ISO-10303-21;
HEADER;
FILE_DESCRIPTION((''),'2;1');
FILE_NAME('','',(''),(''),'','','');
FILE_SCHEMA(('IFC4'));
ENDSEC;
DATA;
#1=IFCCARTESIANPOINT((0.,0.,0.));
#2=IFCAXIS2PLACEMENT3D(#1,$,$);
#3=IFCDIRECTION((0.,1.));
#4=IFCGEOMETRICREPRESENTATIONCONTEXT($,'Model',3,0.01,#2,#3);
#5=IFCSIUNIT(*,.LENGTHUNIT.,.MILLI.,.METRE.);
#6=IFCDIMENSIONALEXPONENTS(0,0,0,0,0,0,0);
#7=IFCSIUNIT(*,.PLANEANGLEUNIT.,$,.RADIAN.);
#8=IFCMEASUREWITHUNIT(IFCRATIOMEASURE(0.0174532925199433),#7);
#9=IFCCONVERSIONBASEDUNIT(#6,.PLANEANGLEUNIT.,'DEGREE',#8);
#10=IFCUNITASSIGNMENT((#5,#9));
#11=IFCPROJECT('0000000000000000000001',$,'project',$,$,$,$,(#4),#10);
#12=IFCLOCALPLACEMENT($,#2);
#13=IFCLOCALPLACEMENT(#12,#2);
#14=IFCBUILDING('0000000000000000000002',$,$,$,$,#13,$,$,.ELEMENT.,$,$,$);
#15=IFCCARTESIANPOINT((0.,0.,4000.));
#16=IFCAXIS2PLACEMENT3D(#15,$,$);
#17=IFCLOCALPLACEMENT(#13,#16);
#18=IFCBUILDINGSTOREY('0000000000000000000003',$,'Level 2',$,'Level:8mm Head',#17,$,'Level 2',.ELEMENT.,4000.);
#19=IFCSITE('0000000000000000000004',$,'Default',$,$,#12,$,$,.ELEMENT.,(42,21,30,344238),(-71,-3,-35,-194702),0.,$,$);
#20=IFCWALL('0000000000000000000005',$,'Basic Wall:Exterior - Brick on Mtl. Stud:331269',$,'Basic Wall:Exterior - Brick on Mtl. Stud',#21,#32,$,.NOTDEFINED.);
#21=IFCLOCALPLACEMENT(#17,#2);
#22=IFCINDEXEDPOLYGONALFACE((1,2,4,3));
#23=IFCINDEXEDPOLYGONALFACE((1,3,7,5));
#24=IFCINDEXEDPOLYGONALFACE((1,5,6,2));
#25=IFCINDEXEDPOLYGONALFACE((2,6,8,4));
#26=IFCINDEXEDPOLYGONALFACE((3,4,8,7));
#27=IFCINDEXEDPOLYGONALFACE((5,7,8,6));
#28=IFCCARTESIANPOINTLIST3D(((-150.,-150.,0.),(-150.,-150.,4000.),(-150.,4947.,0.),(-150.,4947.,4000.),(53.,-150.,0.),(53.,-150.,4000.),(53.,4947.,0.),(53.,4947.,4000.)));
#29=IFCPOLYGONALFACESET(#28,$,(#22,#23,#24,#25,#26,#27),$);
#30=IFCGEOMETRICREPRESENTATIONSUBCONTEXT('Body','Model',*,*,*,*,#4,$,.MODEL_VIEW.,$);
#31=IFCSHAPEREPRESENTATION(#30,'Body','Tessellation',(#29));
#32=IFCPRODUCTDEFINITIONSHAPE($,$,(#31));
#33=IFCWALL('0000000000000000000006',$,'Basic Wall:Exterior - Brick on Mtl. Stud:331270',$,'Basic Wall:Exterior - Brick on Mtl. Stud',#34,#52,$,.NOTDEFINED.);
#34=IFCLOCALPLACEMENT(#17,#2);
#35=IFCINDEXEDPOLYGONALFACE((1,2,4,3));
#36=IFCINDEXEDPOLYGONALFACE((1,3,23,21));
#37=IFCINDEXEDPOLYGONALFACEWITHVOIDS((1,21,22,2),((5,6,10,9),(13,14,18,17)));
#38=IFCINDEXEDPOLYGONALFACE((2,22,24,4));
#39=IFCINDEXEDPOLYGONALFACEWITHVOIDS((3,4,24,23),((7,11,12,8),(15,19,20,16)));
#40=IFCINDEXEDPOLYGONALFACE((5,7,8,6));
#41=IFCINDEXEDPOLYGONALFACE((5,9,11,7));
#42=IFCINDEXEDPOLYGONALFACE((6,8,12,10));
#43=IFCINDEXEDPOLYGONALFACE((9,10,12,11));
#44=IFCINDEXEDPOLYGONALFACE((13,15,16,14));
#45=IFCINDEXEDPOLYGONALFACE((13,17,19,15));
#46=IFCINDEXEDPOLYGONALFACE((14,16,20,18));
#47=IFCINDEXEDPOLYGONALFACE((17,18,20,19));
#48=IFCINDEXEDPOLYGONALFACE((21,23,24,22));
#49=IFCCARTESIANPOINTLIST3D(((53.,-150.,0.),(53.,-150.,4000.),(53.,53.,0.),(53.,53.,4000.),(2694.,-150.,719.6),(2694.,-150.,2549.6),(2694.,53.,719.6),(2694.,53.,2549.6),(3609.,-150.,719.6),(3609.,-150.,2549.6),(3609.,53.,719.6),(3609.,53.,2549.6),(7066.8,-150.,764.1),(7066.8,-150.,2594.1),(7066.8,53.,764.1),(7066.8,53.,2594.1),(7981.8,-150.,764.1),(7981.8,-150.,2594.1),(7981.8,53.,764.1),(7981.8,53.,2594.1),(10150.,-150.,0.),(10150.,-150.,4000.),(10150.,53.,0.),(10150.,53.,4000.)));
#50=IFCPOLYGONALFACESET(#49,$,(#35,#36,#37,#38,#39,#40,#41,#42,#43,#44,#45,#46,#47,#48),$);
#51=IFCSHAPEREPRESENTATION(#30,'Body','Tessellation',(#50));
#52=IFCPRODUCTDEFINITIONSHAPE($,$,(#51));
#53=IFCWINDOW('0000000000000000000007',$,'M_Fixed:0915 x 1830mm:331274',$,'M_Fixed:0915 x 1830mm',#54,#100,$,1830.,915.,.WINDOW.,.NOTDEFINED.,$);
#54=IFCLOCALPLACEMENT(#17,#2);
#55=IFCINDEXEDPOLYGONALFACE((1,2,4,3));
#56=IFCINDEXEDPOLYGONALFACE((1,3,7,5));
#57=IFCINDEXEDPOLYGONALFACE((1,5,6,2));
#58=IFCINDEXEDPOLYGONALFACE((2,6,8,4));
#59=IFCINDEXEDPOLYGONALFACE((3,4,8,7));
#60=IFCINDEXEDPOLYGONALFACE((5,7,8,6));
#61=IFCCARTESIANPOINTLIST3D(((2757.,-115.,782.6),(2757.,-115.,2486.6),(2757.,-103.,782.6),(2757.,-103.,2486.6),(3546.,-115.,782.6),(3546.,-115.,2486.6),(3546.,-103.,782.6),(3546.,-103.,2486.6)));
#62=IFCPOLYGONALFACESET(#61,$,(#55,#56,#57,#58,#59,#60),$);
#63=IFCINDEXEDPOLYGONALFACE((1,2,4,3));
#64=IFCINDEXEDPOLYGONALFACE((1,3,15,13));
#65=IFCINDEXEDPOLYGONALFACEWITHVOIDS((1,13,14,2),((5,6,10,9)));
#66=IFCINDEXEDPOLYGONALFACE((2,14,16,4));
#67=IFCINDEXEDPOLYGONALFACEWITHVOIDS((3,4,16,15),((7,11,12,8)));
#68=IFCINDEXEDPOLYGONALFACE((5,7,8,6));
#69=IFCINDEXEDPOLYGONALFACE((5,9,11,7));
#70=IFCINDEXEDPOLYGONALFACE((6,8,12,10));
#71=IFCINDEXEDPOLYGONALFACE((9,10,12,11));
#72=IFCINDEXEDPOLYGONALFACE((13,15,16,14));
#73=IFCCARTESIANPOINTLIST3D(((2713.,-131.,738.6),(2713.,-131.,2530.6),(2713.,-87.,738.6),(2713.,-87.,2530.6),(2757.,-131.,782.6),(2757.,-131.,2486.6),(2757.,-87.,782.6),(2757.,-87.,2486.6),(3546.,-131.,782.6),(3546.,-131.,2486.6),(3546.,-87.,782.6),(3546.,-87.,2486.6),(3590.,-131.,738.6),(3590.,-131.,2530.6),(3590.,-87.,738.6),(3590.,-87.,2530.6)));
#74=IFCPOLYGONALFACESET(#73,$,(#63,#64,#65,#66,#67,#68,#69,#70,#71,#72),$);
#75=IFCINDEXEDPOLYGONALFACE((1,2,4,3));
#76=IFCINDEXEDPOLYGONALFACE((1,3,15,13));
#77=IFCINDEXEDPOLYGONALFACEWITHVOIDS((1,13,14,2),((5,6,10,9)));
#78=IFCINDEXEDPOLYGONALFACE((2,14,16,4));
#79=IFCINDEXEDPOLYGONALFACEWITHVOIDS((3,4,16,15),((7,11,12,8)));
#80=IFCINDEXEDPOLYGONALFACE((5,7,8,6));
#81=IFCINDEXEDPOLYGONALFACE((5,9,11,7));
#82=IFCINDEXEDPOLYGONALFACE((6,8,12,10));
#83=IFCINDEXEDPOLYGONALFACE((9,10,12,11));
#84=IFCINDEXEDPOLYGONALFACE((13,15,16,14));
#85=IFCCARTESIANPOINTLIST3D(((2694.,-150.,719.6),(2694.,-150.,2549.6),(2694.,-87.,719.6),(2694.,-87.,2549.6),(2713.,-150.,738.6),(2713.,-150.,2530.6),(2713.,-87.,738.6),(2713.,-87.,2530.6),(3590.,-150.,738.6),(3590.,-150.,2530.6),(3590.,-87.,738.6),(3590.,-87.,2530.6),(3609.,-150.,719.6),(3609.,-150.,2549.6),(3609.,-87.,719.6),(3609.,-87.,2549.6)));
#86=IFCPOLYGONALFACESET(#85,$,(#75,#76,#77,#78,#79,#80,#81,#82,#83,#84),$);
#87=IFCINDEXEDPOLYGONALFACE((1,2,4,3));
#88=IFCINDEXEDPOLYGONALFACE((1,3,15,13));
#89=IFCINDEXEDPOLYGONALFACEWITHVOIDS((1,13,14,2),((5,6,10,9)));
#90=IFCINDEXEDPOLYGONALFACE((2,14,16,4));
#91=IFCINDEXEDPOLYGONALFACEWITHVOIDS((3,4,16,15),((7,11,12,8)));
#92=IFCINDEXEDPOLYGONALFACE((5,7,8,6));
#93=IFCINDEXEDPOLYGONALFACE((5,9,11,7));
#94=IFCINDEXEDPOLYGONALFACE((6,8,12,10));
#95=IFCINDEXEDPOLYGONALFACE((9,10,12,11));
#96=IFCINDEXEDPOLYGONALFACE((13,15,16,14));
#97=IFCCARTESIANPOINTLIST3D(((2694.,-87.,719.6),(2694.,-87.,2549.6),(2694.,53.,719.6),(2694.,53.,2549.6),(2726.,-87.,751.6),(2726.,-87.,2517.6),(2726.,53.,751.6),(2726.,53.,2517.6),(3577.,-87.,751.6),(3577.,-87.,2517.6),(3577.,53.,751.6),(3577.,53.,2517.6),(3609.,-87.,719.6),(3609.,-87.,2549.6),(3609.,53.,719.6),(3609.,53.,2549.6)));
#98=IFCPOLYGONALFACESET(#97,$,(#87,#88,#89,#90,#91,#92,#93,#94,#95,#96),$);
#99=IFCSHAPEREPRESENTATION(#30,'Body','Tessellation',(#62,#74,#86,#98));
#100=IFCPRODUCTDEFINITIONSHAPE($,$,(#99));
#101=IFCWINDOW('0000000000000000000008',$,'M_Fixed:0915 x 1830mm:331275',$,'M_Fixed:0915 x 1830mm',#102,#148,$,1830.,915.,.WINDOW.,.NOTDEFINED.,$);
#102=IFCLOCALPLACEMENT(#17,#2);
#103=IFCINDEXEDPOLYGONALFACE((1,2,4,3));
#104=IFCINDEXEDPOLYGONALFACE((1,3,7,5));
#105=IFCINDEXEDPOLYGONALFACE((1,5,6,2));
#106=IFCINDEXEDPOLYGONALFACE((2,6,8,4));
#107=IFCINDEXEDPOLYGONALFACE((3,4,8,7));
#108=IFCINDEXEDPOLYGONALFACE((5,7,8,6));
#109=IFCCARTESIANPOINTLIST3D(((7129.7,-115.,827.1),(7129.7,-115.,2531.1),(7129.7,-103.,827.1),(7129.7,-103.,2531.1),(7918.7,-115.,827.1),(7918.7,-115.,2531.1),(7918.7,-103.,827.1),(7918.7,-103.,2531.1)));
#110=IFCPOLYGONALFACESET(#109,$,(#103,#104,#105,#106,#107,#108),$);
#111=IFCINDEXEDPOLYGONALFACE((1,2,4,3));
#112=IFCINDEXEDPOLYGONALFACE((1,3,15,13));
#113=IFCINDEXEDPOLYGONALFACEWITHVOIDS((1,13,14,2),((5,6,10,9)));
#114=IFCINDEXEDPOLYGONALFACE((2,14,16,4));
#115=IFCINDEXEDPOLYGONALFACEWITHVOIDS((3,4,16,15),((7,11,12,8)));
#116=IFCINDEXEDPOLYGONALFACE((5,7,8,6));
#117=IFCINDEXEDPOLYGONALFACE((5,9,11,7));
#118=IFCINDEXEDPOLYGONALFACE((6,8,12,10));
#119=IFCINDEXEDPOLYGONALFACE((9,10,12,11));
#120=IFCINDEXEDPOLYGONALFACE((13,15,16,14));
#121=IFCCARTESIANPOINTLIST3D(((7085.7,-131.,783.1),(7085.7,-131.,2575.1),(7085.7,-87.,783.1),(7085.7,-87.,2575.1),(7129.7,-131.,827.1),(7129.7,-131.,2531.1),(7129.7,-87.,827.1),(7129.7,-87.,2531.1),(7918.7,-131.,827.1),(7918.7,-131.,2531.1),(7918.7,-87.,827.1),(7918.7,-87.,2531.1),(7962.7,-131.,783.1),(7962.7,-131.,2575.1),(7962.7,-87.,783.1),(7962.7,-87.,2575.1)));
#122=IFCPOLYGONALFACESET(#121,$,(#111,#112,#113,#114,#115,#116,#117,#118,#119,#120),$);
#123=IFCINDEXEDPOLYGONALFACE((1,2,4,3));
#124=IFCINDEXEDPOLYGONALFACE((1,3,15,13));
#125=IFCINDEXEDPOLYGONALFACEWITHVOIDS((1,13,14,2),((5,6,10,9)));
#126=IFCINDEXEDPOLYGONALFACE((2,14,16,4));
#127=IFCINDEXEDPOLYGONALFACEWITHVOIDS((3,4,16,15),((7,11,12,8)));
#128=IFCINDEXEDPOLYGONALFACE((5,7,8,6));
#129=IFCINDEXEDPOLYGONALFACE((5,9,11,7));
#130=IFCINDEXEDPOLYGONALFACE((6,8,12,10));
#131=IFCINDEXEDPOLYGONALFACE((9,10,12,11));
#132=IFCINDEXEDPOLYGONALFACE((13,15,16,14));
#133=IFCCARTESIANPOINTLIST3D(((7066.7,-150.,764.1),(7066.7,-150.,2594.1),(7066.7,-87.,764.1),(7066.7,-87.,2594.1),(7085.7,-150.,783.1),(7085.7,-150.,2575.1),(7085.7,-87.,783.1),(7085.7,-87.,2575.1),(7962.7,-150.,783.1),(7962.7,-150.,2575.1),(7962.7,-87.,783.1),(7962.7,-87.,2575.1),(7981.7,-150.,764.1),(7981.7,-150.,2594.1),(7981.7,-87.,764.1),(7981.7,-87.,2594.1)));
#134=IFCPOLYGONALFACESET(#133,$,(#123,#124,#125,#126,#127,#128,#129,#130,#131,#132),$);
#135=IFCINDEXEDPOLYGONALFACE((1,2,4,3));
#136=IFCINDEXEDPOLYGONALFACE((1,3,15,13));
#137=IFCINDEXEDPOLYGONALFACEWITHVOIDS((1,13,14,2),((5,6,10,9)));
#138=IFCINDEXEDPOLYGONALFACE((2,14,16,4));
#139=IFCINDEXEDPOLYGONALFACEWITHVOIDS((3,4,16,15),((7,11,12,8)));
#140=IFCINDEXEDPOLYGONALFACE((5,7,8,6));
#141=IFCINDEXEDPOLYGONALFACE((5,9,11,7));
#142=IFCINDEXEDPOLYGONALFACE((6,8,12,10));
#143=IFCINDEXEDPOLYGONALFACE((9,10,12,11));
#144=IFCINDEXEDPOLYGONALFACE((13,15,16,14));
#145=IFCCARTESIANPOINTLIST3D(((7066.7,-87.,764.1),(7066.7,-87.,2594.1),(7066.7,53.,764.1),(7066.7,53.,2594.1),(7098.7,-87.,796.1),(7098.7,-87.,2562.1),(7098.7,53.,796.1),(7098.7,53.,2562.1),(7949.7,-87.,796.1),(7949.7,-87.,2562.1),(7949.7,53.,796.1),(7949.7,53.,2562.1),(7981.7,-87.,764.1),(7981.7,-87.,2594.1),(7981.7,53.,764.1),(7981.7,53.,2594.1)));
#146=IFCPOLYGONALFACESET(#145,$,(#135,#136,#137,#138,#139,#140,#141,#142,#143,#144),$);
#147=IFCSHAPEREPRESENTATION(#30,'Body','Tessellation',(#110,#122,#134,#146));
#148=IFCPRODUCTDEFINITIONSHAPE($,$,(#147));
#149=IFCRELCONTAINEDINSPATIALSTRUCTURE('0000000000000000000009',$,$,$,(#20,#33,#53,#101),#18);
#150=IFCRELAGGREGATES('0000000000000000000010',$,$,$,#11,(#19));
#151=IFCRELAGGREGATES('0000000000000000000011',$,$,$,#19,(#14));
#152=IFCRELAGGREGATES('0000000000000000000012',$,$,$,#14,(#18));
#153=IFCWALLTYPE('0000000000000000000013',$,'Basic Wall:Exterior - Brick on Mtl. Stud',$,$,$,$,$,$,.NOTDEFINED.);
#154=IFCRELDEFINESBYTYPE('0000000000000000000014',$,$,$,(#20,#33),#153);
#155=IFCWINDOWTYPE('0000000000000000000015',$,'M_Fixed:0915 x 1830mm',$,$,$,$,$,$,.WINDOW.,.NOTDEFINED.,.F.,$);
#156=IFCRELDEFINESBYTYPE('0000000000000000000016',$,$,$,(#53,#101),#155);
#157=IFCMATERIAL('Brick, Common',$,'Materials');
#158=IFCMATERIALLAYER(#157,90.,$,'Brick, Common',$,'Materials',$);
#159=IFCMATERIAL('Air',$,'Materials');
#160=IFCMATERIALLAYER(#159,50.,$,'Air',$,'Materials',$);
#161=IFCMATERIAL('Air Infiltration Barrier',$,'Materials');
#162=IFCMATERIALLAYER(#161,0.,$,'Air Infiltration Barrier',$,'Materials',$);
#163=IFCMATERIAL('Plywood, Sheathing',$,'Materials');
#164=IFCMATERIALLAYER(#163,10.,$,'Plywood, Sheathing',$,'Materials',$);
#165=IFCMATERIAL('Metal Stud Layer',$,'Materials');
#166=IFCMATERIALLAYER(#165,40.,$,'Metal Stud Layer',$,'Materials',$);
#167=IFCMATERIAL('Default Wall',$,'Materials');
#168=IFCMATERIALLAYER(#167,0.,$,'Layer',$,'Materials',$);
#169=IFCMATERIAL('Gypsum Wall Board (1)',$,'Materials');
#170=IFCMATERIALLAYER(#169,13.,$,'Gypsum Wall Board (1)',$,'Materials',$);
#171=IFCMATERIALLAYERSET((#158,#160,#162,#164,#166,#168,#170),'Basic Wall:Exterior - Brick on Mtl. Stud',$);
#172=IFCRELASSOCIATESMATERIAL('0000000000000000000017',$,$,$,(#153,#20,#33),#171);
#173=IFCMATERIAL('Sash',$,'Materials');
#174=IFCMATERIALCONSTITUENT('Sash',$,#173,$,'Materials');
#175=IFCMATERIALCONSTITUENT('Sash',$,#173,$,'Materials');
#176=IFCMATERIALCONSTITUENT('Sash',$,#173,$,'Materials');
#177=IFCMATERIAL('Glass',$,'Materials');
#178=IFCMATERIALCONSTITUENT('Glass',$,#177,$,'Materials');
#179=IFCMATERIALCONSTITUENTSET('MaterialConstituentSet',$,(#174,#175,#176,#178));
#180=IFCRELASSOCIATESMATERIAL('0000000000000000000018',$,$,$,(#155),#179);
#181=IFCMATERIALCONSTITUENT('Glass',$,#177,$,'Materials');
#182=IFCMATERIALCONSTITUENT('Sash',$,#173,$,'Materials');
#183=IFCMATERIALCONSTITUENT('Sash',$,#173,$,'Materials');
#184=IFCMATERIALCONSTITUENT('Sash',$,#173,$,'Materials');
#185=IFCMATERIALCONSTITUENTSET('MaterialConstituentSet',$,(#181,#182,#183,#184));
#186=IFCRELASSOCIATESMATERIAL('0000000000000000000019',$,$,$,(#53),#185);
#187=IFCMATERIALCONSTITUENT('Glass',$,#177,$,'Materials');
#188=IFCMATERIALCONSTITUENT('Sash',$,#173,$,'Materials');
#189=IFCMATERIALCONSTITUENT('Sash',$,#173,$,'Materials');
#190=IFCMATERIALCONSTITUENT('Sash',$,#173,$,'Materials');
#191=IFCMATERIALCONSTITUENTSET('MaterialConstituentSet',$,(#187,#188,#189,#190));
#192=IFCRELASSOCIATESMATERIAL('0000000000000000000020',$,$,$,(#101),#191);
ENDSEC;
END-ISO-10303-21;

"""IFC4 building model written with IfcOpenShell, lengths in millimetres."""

from ifc_helpers import new_model, entity, si_unit, converted_unit, direction, frame, frame_2d, origin, place, context, subcontext, project, spatial, polyline, rectangle, outline, extrude, source, transform, mapped, material, layer, layer_set, layer_usage, constituent, constituent_set, type_object, type_shapes, element, fill, save


model = new_model("IFC4")

# Units and contexts
model_context = context("Model", 3, precision=0.01, world=origin(), true_north=direction((0.0, 1.0)))
body_context = subcontext(model_context, "Body", "Model", "MODEL_VIEW")
ifc_project = project(units=[si_unit("LENGTHUNIT", "METRE", prefix="MILLI"), converted_unit("PLANEANGLEUNIT", "DEGREE", entity("IfcRatioMeasure", 0.0174532925199433), si_unit("PLANEANGLEUNIT", "RADIAN"), dimensions=[0, 0, 0, 0, 0, 0, 0])], contexts=[model_context])

# Site, building, storey
site_placement = place(None, origin())
site = spatial("IfcSite", under=ifc_project, at=site_placement, Name="Default", CompositionType="ELEMENT", RefLatitude=(42, 21, 30, 344238), RefLongitude=(-71, -3, -35, -194702), RefElevation=0.0)
building_placement = place(site_placement, origin())
building = spatial("IfcBuilding", under=site, at=building_placement, CompositionType="ELEMENT")
storey_placement = place(building_placement, frame((0.0, 0.0, 4000.0)))
storey = spatial("IfcBuildingStorey", under=building, at=storey_placement, Name="Level 2", ObjectType="Level:8mm Head", LongName="Level 2", CompositionType="ELEMENT", Elevation=4000.0)

# Shared definitions
ifc_material_1 = material(Name="Brick, Common", Category="Materials")
ifc_layer_1 = layer(ifc_material_1, 90.0, Name="Brick, Common", Category="Materials")
ifc_material_2 = material(Name="Air", Category="Materials")
ifc_layer_2 = layer(ifc_material_2, 50.0, Name="Air", Category="Materials")
ifc_material_3 = material(Name="Air Infiltration Barrier", Category="Materials")
ifc_layer_3 = layer(ifc_material_3, 0.0, Name="Air Infiltration Barrier", Category="Materials")
ifc_material_4 = material(Name="Plywood, Sheathing", Category="Materials")
ifc_layer_4 = layer(ifc_material_4, 10.0, Name="Plywood, Sheathing", Category="Materials")
ifc_material_5 = material(Name="Metal Stud Layer", Category="Materials")
ifc_layer_5 = layer(ifc_material_5, 40.0, Name="Metal Stud Layer", Category="Materials")
ifc_material_6 = material(Name="Default Wall", Category="Materials")
ifc_layer_6 = layer(ifc_material_6, 0.0, Name="Layer", Category="Materials")
ifc_material_7 = material(Name="Gypsum Wall Board (1)", Category="Materials")
ifc_layer_7 = layer(ifc_material_7, 13.0, Name="Gypsum Wall Board (1)", Category="Materials")
ifc_layer_set_1 = layer_set([ifc_layer_1, ifc_layer_2, ifc_layer_3, ifc_layer_4, ifc_layer_5, ifc_layer_6, ifc_layer_7], Name="Basic Wall:Exterior - Brick on Mtl. Stud")
wall_type_1 = type_object("IfcWallType", Name="Basic Wall:Exterior - Brick on Mtl. Stud", PredefinedType="NOTDEFINED", material=ifc_layer_set_1)
ifc_material_8 = material(Name="Glass", Category="Materials")
ifc_material_9 = material(Name="Sash", Category="Materials")
ifc_constituent_1 = constituent(ifc_material_9, Name="Sash", Category="Materials")
ifc_constituent_2 = constituent(ifc_material_9, Name="Sash", Category="Materials")
ifc_constituent_3 = constituent(ifc_material_9, Name="Sash", Category="Materials")
ifc_constituent_4 = constituent(ifc_material_8, Name="Glass", Category="Materials")
ifc_constituent_set_1 = constituent_set(constituents=[ifc_constituent_1, ifc_constituent_2, ifc_constituent_3, ifc_constituent_4], Name="MaterialConstituentSet")
window_type = type_object("IfcWindowType", Name="M_Fixed:0915 x 1830mm", ParameterTakesPrecedence=False, PartitioningType="NOTDEFINED", PredefinedType="WINDOW", material=ifc_constituent_set_1)
shared_shape_1 = source(origin(), body_context, "Body", "SweptSolid", [
    extrude(rectangle(XDim=12.0, YDim=789.0, at=frame_2d((0.0, 0.0), x_axis=(1.0, 0.0))), frame((457.5, 162.0, 63.0), z_axis=(0.0, 0.0, 1.0), x_axis=(0.0, -1.0, 0.0)), (0.0, 0.0, 1.0), 1704.0),
    extrude(outline(polyline([(-438.5, -896.0), (438.5, -896.0), (438.5, 896.0), (-438.5, 896.0), (-438.5, -896.0)]), holes=[polyline([(-394.5, -852.0), (-394.5, 852.0), (394.5, 852.0), (394.5, -852.0), (-394.5, -852.0)])]), frame((457.5, 140.0, 915.0), z_axis=(0.0, 1.0, 0.0), x_axis=(1.0, 0.0, 0.0)), (0.0, 0.0, 1.0), 44.0),
    extrude(outline(polyline([(-457.5, -915.0), (457.5, -915.0), (457.5, 915.0), (-457.5, 915.0), (-457.5, -915.0)]), holes=[polyline([(-438.5, -896.0), (-438.5, 896.0), (438.5, 896.0), (438.5, -896.0), (-438.5, -896.0)])]), frame((457.5, 140.0, 915.0), z_axis=(0.0, 1.0, 0.0), x_axis=(1.0, 0.0, 0.0)), (0.0, 0.0, 1.0), 63.0),
    extrude(outline(polyline([(-457.5, -915.0), (457.5, -915.0), (457.5, 915.0), (-457.5, 915.0), (-457.5, -915.0)]), holes=[polyline([(-425.5, -883.0), (-425.5, 883.0), (425.5, 883.0), (425.5, -883.0), (-425.5, -883.0)])]), frame((457.5, 0.0, 915.0), z_axis=(0.0, 1.0, 0.0), x_axis=(1.0, 0.0, 0.0)), (0.0, 0.0, 1.0), 140.0),
])
type_shapes(window_type, [shared_shape_1])

# Wall
ifc_layer_usage_1 = layer_usage(ifc_layer_set_1, "AXIS2", "NEGATIVE", 101.5)
wall_1_placement = place(storey_placement, frame((-48.5, -150.0, 0.0), z_axis=(0.0, 0.0, 1.0), x_axis=(0.0, 1.0, 0.0)))
element("IfcWall", 1, at=wall_1_placement, inside=storey, type_object=wall_type_1, material=ifc_layer_usage_1, Name="Basic Wall:Exterior - Brick on Mtl. Stud:331269", ObjectType="Basic Wall:Exterior - Brick on Mtl. Stud", PredefinedType="NOTDEFINED", context=body_context, shape_type="SweptSolid", body=[
    extrude(rectangle(XDim=5097.0, YDim=203.0, at=frame_2d((2548.5, 0.0), x_axis=(-1.0, 0.0))), origin(), (0.0, 0.0, 1.0), 4000.0),
])

# Wall, openings, windows
ifc_layer_usage_2 = layer_usage(ifc_layer_set_1, "AXIS2", "NEGATIVE", 101.5)
wall_2_placement = place(storey_placement, frame((10150.0, -48.5, 0.0), z_axis=(0.0, 0.0, 1.0), x_axis=(-1.0, 0.0, 0.0)))
wall_2 = element("IfcWall", 2, at=wall_2_placement, inside=storey, type_object=wall_type_1, material=ifc_layer_usage_2, Name="Basic Wall:Exterior - Brick on Mtl. Stud:331270", ObjectType="Basic Wall:Exterior - Brick on Mtl. Stud", PredefinedType="NOTDEFINED", context=body_context, shape_type="SweptSolid", body=[
    extrude(rectangle(XDim=10097.0, YDim=203.0, at=frame_2d((5048.5, 0.0), x_axis=(-1.0, 0.0))), origin(), (0.0, 0.0, 1.0), 4000.0),
])
opening_1_placement = place(wall_2_placement, frame((6541.0, -101.5, 719.6)))
opening_1 = element("IfcOpeningElement", 3, at=opening_1_placement, cuts=wall_2, ObjectType="Opening", PredefinedType="OPENING", context=body_context, shape_type="SweptSolid", body=[
    extrude(rectangle(XDim=1830.0, YDim=915.0, at=frame_2d((915.0, 457.5), x_axis=(1.0, 0.0))), frame((0.0, 0.0, 0.0), z_axis=(0.0, 1.0, 0.0), x_axis=(0.0, 0.0, 1.0)), (0.0, 0.0, 1.0), 203.0),
])
opening_2_placement = place(wall_2_placement, frame((2168.2, -101.5, 764.1)))
opening_2 = element("IfcOpeningElement", 4, at=opening_2_placement, cuts=wall_2, ObjectType="Opening", PredefinedType="OPENING", context=body_context, shape_type="SweptSolid", body=[
    extrude(rectangle(XDim=1830.0, YDim=915.0, at=frame_2d((915.0, 457.5), x_axis=(1.0, 0.0))), frame((0.0, 0.0, 0.0), z_axis=(0.0, 1.0, 0.0), x_axis=(0.0, 0.0, 1.0)), (0.0, 0.0, 1.0), 203.0),
])
ifc_constituent_5 = constituent(ifc_material_8, Name="Glass", Category="Materials")
ifc_constituent_6 = constituent(ifc_material_9, Name="Sash", Category="Materials")
ifc_constituent_7 = constituent(ifc_material_9, Name="Sash", Category="Materials")
ifc_constituent_8 = constituent(ifc_material_9, Name="Sash", Category="Materials")
ifc_constituent_set_2 = constituent_set(constituents=[ifc_constituent_5, ifc_constituent_6, ifc_constituent_7, ifc_constituent_8], Name="MaterialConstituentSet")
window_1_placement = place(opening_1_placement, origin())
window_1 = element("IfcWindow", 5, at=window_1_placement, inside=storey, type_object=window_type, material=ifc_constituent_set_2, Name="M_Fixed:0915 x 1830mm:331274", ObjectType="M_Fixed:0915 x 1830mm", OverallHeight=1830.0, OverallWidth=915.0, PartitioningType="NOTDEFINED", PredefinedType="WINDOW", context=body_context, shape_type="MappedRepresentation", body=[
    mapped(shared_shape_1, transform((0.0, 0.0, 0.0), scale=1.0)),
])
fill(opening_1, window_1)
ifc_constituent_9 = constituent(ifc_material_8, Name="Glass", Category="Materials")
ifc_constituent_10 = constituent(ifc_material_9, Name="Sash", Category="Materials")
ifc_constituent_11 = constituent(ifc_material_9, Name="Sash", Category="Materials")
ifc_constituent_12 = constituent(ifc_material_9, Name="Sash", Category="Materials")
ifc_constituent_set_3 = constituent_set(constituents=[ifc_constituent_9, ifc_constituent_10, ifc_constituent_11, ifc_constituent_12], Name="MaterialConstituentSet")
window_2_placement = place(opening_2_placement, origin())
window_2 = element("IfcWindow", 6, at=window_2_placement, inside=storey, type_object=window_type, material=ifc_constituent_set_3, Name="M_Fixed:0915 x 1830mm:331275", ObjectType="M_Fixed:0915 x 1830mm", OverallHeight=1830.0, OverallWidth=915.0, PartitioningType="NOTDEFINED", PredefinedType="WINDOW", context=body_context, shape_type="MappedRepresentation", body=[
    mapped(shared_shape_1, transform((0.0, 0.0, 0.0), scale=1.0)),
])
fill(opening_2, window_2)

save(model, "model.ifc")
